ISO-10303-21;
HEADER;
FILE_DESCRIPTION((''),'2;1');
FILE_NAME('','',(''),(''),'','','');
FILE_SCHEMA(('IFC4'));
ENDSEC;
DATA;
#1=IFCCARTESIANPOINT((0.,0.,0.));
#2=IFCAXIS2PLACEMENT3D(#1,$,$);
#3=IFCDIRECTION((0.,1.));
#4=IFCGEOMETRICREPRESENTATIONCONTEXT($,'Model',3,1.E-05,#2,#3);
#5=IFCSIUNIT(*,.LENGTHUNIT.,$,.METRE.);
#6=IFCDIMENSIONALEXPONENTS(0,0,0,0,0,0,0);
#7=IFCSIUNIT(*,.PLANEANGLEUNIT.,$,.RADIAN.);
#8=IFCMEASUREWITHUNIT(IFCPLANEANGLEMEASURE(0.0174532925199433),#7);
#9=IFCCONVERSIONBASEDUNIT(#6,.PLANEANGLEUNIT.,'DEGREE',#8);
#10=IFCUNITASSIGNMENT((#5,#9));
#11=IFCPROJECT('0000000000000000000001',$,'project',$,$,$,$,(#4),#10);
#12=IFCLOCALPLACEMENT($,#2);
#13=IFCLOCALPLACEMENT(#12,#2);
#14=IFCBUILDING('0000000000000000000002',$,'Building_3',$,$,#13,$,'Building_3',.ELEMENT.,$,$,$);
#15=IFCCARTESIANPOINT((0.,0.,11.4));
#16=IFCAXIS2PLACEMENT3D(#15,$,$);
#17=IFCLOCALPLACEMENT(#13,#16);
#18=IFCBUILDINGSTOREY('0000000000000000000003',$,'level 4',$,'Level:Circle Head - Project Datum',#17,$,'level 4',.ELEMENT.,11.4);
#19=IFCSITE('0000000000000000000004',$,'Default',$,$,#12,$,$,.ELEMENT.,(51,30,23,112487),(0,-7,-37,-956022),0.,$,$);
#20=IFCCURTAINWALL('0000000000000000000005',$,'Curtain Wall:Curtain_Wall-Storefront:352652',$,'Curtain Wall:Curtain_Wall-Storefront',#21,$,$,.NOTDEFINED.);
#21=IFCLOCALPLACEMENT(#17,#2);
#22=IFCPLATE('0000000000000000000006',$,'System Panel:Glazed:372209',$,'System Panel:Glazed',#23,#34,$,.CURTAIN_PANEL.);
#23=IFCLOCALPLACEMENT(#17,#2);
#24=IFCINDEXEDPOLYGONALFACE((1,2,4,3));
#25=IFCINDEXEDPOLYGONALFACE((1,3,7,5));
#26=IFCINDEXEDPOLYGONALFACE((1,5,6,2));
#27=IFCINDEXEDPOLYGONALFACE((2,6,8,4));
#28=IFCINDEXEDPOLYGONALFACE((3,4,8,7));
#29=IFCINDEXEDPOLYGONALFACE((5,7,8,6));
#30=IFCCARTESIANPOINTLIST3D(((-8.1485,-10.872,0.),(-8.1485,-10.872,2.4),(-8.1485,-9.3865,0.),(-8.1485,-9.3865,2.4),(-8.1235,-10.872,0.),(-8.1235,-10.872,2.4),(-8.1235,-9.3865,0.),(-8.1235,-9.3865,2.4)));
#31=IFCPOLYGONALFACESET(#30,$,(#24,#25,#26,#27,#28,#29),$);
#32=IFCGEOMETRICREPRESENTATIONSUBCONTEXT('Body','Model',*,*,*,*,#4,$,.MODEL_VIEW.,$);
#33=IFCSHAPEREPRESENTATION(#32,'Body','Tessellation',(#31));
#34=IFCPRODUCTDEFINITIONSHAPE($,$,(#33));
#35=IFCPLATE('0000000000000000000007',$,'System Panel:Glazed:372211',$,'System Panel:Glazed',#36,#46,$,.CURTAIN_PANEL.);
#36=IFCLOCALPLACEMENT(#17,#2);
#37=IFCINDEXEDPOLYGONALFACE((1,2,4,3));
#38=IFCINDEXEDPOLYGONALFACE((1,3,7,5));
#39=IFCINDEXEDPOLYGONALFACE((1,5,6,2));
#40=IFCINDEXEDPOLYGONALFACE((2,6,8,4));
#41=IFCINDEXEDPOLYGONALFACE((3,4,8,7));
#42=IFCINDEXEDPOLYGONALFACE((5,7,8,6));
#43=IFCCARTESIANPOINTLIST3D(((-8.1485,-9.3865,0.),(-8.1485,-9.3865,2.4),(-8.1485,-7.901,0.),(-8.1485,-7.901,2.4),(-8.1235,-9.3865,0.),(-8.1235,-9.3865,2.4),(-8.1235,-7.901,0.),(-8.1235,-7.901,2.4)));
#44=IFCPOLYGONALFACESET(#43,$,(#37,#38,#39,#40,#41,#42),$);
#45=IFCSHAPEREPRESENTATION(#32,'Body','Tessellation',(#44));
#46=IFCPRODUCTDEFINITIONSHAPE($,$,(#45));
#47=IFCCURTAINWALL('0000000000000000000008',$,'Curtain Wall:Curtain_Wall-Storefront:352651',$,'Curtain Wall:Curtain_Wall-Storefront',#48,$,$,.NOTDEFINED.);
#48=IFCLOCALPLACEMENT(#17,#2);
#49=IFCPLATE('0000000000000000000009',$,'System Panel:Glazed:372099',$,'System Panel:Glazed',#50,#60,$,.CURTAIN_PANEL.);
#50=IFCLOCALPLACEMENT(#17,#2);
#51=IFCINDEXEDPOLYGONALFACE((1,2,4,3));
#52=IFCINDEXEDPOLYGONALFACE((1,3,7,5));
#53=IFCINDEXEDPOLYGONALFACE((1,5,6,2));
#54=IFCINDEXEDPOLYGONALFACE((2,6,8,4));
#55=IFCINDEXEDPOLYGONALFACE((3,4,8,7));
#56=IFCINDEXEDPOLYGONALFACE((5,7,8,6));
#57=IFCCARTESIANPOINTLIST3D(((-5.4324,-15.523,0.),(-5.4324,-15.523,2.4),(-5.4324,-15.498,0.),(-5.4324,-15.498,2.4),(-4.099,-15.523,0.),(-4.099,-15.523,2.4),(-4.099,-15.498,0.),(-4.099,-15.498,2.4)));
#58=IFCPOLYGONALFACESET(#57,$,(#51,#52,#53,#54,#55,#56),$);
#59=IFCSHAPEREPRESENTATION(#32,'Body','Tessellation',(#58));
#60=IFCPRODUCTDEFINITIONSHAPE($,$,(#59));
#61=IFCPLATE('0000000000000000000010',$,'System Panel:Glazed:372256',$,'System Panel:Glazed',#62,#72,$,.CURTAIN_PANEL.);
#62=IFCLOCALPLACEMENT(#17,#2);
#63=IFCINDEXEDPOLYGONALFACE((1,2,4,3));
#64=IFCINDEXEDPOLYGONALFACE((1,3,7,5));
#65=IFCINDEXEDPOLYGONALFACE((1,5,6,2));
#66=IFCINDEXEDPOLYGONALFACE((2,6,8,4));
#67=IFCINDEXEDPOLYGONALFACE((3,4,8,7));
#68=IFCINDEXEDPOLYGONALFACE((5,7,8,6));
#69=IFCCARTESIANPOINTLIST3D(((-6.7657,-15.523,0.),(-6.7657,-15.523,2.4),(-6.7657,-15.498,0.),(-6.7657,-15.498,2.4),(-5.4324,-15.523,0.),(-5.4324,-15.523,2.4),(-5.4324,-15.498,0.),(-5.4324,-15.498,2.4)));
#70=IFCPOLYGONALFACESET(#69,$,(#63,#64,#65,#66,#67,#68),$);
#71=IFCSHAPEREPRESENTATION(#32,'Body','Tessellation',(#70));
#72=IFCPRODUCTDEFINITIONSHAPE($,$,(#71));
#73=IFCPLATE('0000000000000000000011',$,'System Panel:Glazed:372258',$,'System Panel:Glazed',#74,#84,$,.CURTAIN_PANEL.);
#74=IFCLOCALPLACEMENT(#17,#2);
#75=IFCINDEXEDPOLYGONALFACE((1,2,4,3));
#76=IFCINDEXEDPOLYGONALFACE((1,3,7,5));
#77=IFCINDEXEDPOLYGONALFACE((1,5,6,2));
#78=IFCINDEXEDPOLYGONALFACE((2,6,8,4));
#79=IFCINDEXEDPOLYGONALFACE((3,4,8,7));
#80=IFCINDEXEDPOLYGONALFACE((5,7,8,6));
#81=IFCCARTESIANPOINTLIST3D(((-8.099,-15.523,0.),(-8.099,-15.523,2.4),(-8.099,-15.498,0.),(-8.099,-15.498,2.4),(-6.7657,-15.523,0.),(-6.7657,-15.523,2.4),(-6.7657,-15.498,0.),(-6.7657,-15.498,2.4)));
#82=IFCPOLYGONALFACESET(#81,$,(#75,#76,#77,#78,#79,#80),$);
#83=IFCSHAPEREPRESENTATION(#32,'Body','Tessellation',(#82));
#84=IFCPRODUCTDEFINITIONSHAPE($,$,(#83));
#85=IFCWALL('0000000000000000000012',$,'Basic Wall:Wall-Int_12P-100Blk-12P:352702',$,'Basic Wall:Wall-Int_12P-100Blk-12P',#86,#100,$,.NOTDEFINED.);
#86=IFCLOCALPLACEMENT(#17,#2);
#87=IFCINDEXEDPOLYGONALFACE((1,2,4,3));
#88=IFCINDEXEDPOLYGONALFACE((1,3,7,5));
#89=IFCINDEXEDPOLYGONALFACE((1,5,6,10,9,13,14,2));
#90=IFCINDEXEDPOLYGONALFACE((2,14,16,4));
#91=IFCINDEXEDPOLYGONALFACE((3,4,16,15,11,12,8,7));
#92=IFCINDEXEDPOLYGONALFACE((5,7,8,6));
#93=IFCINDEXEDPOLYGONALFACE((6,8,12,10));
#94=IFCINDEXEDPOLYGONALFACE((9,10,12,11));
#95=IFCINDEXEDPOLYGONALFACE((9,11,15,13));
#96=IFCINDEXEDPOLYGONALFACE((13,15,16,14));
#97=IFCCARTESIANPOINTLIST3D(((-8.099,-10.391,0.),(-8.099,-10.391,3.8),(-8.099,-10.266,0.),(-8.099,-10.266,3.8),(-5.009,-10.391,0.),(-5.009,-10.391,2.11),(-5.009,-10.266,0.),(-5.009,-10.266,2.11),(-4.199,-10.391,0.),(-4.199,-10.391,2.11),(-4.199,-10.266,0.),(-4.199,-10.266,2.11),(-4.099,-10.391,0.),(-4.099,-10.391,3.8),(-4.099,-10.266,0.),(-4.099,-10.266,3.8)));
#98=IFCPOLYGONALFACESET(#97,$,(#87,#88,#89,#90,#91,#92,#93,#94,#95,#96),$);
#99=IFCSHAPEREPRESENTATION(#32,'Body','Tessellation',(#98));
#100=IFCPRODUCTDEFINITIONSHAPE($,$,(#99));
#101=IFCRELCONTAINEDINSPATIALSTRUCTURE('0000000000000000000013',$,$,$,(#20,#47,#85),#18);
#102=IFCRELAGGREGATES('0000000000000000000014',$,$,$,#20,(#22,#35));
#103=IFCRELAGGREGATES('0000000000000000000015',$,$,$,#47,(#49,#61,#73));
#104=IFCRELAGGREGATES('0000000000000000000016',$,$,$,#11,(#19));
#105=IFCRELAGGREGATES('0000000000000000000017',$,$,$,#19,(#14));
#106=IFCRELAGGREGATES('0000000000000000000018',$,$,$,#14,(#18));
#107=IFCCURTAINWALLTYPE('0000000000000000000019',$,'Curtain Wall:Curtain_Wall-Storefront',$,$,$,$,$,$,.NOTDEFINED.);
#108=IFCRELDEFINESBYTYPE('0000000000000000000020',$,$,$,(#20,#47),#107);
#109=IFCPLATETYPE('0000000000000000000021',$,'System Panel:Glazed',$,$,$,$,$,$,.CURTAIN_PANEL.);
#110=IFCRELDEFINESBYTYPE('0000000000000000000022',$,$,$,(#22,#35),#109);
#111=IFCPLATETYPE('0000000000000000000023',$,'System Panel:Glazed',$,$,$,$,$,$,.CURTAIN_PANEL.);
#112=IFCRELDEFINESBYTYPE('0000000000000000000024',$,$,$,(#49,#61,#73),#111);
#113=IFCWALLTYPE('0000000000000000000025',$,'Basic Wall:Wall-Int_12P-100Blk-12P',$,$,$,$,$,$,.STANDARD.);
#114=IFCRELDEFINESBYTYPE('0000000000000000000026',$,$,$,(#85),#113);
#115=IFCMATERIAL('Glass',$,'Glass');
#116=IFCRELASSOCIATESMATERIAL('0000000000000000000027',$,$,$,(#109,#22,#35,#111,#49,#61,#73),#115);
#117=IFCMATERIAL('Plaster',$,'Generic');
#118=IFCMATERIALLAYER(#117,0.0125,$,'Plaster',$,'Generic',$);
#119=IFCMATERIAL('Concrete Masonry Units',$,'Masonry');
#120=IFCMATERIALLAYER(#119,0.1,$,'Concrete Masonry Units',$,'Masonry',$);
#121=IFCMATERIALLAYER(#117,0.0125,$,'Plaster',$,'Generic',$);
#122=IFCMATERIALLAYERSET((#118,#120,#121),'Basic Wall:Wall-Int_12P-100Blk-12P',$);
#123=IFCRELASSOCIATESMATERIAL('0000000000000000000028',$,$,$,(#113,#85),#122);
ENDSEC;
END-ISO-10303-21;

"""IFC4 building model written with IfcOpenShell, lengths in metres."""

from ifc_helpers import new_model, entity, si_unit, converted_unit, direction, frame, frame_2d, origin, origin_2d_with_axis, place, context, subcontext, project, spatial, rectangle, extrude, source, transform, mapped, material, layer, layer_set, layer_usage, type_object, type_shapes, element, aggregate, save


model = new_model("IFC4")

# Units and contexts
model_context = context("Model", 3, precision=1e-05, world=origin(), true_north=direction((0.0, 1.0)))
body_context = subcontext(model_context, "Body", "Model", "MODEL_VIEW")
ifc_project = project(units=[si_unit("LENGTHUNIT", "METRE"), converted_unit("PLANEANGLEUNIT", "DEGREE", entity("IfcPlaneAngleMeasure", 0.0174532925199433), si_unit("PLANEANGLEUNIT", "RADIAN"), dimensions=[0, 0, 0, 0, 0, 0, 0])], contexts=[model_context])

# Site, building, storey
site_placement = place(None, origin())
site = spatial("IfcSite", under=ifc_project, at=site_placement, Name="Default", CompositionType="ELEMENT", RefLatitude=(51, 30, 23, 112487), RefLongitude=(0, -7, -37, -956022), RefElevation=0.0)
building_placement = place(site_placement, origin())
building = spatial("IfcBuilding", under=site, at=building_placement, Name="Building_3", LongName="Building_3", CompositionType="ELEMENT")
storey_placement = place(building_placement, frame((0.0, 0.0, 11.4)))
storey = spatial("IfcBuildingStorey", under=building, at=storey_placement, Name="level 4", ObjectType="Level:Circle Head - Project Datum", LongName="level 4", CompositionType="ELEMENT", Elevation=11.4)

# Curtain walls, plates
curtain_wall_type = type_object("IfcCurtainWallType", Name="Curtain Wall:Curtain_Wall-Storefront", PredefinedType="NOTDEFINED")
ifc_material_1 = material(Name="Glass", Category="Glass")
plate_type_1 = type_object("IfcPlateType", Name="System Panel:Glazed", PredefinedType="CURTAIN_PANEL", material=ifc_material_1)
shared_shape_1 = source(origin(), body_context, "Body", "SweptSolid", [
    extrude(rectangle(XDim=0.025, YDim=1.4855, at=origin_2d_with_axis()), frame((0.7428, 0.0125, 0.0), z_axis=(0.0, 0.0, 1.0), x_axis=(0.0, 1.0, 0.0)), (0.0, 0.0, 1.0), 2.4),
])
type_shapes(plate_type_1, [shared_shape_1])
curtain_wall_1_placement = place(storey_placement, frame((0.0, 0.0, -11.4)))
curtain_wall_1 = element("IfcCurtainWall", 1, at=curtain_wall_1_placement, inside=storey, type_object=curtain_wall_type, Name="Curtain Wall:Curtain_Wall-Storefront:352652", ObjectType="Curtain Wall:Curtain_Wall-Storefront", PredefinedType="NOTDEFINED")
plate_1_placement = place(curtain_wall_1_placement, frame((-8.1235, -10.872, 11.4), z_axis=(0.0, 0.0, 1.0), x_axis=(0.0, 1.0, 0.0)))
plate_1 = element("IfcPlate", 2, at=plate_1_placement, type_object=plate_type_1, material=ifc_material_1, Name="System Panel:Glazed:372209", ObjectType="System Panel:Glazed", PredefinedType="CURTAIN_PANEL", context=body_context, shape_type="MappedRepresentation", body=[
    mapped(shared_shape_1, transform((0.0, 0.0, 0.0), scale=1.0)),
])
plate_2_placement = place(curtain_wall_1_placement, frame((-8.1235, -9.3865, 11.4), z_axis=(0.0, 0.0, 1.0), x_axis=(0.0, 1.0, 0.0)))
plate_2 = element("IfcPlate", 3, at=plate_2_placement, type_object=plate_type_1, material=ifc_material_1, Name="System Panel:Glazed:372211", ObjectType="System Panel:Glazed", PredefinedType="CURTAIN_PANEL", context=body_context, shape_type="MappedRepresentation", body=[
    mapped(shared_shape_1, transform((0.0, 0.0, 0.0), scale=1.0)),
])
aggregate(curtain_wall_1, [plate_1, plate_2])
curtain_wall_2_placement = place(storey_placement, frame((0.0, 0.0, -11.4)))
curtain_wall_2 = element("IfcCurtainWall", 4, at=curtain_wall_2_placement, inside=storey, type_object=curtain_wall_type, Name="Curtain Wall:Curtain_Wall-Storefront:352651", ObjectType="Curtain Wall:Curtain_Wall-Storefront", PredefinedType="NOTDEFINED")
plate_type_2 = type_object("IfcPlateType", Name="System Panel:Glazed", PredefinedType="CURTAIN_PANEL", material=ifc_material_1)
shared_shape_2 = source(origin(), body_context, "Body", "SweptSolid", [
    extrude(rectangle(XDim=0.025, YDim=1.3333, at=origin_2d_with_axis()), frame((0.6667, 0.0125, 0.0), z_axis=(0.0, 0.0, 1.0), x_axis=(0.0, 1.0, 0.0)), (0.0, 0.0, 1.0), 2.4),
])
type_shapes(plate_type_2, [shared_shape_2])
plate_3_placement = place(curtain_wall_2_placement, frame((-4.099, -15.498, 11.4), z_axis=(0.0, 0.0, 1.0), x_axis=(-1.0, 0.0, 0.0)))
plate_3 = element("IfcPlate", 5, at=plate_3_placement, type_object=plate_type_2, material=ifc_material_1, Name="System Panel:Glazed:372099", ObjectType="System Panel:Glazed", PredefinedType="CURTAIN_PANEL", context=body_context, shape_type="MappedRepresentation", body=[
    mapped(shared_shape_2, transform((0.0, 0.0, 0.0), scale=1.0)),
])
plate_4_placement = place(curtain_wall_2_placement, frame((-5.4324, -15.498, 11.4), z_axis=(0.0, 0.0, 1.0), x_axis=(-1.0, 0.0, 0.0)))
plate_4 = element("IfcPlate", 6, at=plate_4_placement, type_object=plate_type_2, material=ifc_material_1, Name="System Panel:Glazed:372256", ObjectType="System Panel:Glazed", PredefinedType="CURTAIN_PANEL", context=body_context, shape_type="MappedRepresentation", body=[
    mapped(shared_shape_2, transform((0.0, 0.0, 0.0), scale=1.0)),
])
plate_5_placement = place(curtain_wall_2_placement, frame((-6.7657, -15.498, 11.4), z_axis=(0.0, 0.0, 1.0), x_axis=(-1.0, 0.0, 0.0)))
plate_5 = element("IfcPlate", 7, at=plate_5_placement, type_object=plate_type_2, material=ifc_material_1, Name="System Panel:Glazed:372258", ObjectType="System Panel:Glazed", PredefinedType="CURTAIN_PANEL", context=body_context, shape_type="MappedRepresentation", body=[
    mapped(shared_shape_2, transform((0.0, 0.0, 0.0), scale=1.0)),
])
aggregate(curtain_wall_2, [plate_3, plate_4, plate_5])

# Wall, opening
ifc_material_2 = material(Name="Plaster", Category="Generic")
ifc_layer_1 = layer(ifc_material_2, 0.0125, Name="Plaster", Category="Generic")
ifc_material_3 = material(Name="Concrete Masonry Units", Category="Masonry")
ifc_layer_2 = layer(ifc_material_3, 0.1, Name="Concrete Masonry Units", Category="Masonry")
ifc_layer_3 = layer(ifc_material_2, 0.0125, Name="Plaster", Category="Generic")
ifc_layer_set = layer_set([ifc_layer_1, ifc_layer_2, ifc_layer_3], Name="Basic Wall:Wall-Int_12P-100Blk-12P")
ifc_layer_usage = layer_usage(ifc_layer_set, "AXIS2", "NEGATIVE", 0.0625)
wall_type = type_object("IfcWallType", Name="Basic Wall:Wall-Int_12P-100Blk-12P", PredefinedType="STANDARD", material=ifc_layer_set)
wall_placement = place(storey_placement, frame((-8.099, -10.3285, 0.0)))
wall = element("IfcWall", 8, at=wall_placement, inside=storey, type_object=wall_type, material=ifc_layer_usage, Name="Basic Wall:Wall-Int_12P-100Blk-12P:352702", ObjectType="Basic Wall:Wall-Int_12P-100Blk-12P", PredefinedType="NOTDEFINED", context=body_context, shape_type="SweptSolid", body=[
    extrude(rectangle(XDim=4.0, YDim=0.125, at=frame_2d((2.0, 0.0), x_axis=(-1.0, 0.0))), origin(), (0.0, 0.0, 1.0), 3.8),
])
opening_placement = place(wall_placement, frame((3.9, 0.0625, 0.0)))
element("IfcOpeningElement", 9, at=opening_placement, cuts=wall, PredefinedType="OPENING", context=body_context, shape_type="SweptSolid", body=[
    extrude(rectangle(XDim=2.11, YDim=0.81, at=frame_2d((1.055, 0.405), x_axis=(1.0, 0.0))), frame((0.0, 0.0, 0.0), z_axis=(0.0, -1.0, 0.0), x_axis=(0.0, 0.0, 1.0)), (0.0, 0.0, 1.0), 0.125),
])

save(model, "model.ifc")
